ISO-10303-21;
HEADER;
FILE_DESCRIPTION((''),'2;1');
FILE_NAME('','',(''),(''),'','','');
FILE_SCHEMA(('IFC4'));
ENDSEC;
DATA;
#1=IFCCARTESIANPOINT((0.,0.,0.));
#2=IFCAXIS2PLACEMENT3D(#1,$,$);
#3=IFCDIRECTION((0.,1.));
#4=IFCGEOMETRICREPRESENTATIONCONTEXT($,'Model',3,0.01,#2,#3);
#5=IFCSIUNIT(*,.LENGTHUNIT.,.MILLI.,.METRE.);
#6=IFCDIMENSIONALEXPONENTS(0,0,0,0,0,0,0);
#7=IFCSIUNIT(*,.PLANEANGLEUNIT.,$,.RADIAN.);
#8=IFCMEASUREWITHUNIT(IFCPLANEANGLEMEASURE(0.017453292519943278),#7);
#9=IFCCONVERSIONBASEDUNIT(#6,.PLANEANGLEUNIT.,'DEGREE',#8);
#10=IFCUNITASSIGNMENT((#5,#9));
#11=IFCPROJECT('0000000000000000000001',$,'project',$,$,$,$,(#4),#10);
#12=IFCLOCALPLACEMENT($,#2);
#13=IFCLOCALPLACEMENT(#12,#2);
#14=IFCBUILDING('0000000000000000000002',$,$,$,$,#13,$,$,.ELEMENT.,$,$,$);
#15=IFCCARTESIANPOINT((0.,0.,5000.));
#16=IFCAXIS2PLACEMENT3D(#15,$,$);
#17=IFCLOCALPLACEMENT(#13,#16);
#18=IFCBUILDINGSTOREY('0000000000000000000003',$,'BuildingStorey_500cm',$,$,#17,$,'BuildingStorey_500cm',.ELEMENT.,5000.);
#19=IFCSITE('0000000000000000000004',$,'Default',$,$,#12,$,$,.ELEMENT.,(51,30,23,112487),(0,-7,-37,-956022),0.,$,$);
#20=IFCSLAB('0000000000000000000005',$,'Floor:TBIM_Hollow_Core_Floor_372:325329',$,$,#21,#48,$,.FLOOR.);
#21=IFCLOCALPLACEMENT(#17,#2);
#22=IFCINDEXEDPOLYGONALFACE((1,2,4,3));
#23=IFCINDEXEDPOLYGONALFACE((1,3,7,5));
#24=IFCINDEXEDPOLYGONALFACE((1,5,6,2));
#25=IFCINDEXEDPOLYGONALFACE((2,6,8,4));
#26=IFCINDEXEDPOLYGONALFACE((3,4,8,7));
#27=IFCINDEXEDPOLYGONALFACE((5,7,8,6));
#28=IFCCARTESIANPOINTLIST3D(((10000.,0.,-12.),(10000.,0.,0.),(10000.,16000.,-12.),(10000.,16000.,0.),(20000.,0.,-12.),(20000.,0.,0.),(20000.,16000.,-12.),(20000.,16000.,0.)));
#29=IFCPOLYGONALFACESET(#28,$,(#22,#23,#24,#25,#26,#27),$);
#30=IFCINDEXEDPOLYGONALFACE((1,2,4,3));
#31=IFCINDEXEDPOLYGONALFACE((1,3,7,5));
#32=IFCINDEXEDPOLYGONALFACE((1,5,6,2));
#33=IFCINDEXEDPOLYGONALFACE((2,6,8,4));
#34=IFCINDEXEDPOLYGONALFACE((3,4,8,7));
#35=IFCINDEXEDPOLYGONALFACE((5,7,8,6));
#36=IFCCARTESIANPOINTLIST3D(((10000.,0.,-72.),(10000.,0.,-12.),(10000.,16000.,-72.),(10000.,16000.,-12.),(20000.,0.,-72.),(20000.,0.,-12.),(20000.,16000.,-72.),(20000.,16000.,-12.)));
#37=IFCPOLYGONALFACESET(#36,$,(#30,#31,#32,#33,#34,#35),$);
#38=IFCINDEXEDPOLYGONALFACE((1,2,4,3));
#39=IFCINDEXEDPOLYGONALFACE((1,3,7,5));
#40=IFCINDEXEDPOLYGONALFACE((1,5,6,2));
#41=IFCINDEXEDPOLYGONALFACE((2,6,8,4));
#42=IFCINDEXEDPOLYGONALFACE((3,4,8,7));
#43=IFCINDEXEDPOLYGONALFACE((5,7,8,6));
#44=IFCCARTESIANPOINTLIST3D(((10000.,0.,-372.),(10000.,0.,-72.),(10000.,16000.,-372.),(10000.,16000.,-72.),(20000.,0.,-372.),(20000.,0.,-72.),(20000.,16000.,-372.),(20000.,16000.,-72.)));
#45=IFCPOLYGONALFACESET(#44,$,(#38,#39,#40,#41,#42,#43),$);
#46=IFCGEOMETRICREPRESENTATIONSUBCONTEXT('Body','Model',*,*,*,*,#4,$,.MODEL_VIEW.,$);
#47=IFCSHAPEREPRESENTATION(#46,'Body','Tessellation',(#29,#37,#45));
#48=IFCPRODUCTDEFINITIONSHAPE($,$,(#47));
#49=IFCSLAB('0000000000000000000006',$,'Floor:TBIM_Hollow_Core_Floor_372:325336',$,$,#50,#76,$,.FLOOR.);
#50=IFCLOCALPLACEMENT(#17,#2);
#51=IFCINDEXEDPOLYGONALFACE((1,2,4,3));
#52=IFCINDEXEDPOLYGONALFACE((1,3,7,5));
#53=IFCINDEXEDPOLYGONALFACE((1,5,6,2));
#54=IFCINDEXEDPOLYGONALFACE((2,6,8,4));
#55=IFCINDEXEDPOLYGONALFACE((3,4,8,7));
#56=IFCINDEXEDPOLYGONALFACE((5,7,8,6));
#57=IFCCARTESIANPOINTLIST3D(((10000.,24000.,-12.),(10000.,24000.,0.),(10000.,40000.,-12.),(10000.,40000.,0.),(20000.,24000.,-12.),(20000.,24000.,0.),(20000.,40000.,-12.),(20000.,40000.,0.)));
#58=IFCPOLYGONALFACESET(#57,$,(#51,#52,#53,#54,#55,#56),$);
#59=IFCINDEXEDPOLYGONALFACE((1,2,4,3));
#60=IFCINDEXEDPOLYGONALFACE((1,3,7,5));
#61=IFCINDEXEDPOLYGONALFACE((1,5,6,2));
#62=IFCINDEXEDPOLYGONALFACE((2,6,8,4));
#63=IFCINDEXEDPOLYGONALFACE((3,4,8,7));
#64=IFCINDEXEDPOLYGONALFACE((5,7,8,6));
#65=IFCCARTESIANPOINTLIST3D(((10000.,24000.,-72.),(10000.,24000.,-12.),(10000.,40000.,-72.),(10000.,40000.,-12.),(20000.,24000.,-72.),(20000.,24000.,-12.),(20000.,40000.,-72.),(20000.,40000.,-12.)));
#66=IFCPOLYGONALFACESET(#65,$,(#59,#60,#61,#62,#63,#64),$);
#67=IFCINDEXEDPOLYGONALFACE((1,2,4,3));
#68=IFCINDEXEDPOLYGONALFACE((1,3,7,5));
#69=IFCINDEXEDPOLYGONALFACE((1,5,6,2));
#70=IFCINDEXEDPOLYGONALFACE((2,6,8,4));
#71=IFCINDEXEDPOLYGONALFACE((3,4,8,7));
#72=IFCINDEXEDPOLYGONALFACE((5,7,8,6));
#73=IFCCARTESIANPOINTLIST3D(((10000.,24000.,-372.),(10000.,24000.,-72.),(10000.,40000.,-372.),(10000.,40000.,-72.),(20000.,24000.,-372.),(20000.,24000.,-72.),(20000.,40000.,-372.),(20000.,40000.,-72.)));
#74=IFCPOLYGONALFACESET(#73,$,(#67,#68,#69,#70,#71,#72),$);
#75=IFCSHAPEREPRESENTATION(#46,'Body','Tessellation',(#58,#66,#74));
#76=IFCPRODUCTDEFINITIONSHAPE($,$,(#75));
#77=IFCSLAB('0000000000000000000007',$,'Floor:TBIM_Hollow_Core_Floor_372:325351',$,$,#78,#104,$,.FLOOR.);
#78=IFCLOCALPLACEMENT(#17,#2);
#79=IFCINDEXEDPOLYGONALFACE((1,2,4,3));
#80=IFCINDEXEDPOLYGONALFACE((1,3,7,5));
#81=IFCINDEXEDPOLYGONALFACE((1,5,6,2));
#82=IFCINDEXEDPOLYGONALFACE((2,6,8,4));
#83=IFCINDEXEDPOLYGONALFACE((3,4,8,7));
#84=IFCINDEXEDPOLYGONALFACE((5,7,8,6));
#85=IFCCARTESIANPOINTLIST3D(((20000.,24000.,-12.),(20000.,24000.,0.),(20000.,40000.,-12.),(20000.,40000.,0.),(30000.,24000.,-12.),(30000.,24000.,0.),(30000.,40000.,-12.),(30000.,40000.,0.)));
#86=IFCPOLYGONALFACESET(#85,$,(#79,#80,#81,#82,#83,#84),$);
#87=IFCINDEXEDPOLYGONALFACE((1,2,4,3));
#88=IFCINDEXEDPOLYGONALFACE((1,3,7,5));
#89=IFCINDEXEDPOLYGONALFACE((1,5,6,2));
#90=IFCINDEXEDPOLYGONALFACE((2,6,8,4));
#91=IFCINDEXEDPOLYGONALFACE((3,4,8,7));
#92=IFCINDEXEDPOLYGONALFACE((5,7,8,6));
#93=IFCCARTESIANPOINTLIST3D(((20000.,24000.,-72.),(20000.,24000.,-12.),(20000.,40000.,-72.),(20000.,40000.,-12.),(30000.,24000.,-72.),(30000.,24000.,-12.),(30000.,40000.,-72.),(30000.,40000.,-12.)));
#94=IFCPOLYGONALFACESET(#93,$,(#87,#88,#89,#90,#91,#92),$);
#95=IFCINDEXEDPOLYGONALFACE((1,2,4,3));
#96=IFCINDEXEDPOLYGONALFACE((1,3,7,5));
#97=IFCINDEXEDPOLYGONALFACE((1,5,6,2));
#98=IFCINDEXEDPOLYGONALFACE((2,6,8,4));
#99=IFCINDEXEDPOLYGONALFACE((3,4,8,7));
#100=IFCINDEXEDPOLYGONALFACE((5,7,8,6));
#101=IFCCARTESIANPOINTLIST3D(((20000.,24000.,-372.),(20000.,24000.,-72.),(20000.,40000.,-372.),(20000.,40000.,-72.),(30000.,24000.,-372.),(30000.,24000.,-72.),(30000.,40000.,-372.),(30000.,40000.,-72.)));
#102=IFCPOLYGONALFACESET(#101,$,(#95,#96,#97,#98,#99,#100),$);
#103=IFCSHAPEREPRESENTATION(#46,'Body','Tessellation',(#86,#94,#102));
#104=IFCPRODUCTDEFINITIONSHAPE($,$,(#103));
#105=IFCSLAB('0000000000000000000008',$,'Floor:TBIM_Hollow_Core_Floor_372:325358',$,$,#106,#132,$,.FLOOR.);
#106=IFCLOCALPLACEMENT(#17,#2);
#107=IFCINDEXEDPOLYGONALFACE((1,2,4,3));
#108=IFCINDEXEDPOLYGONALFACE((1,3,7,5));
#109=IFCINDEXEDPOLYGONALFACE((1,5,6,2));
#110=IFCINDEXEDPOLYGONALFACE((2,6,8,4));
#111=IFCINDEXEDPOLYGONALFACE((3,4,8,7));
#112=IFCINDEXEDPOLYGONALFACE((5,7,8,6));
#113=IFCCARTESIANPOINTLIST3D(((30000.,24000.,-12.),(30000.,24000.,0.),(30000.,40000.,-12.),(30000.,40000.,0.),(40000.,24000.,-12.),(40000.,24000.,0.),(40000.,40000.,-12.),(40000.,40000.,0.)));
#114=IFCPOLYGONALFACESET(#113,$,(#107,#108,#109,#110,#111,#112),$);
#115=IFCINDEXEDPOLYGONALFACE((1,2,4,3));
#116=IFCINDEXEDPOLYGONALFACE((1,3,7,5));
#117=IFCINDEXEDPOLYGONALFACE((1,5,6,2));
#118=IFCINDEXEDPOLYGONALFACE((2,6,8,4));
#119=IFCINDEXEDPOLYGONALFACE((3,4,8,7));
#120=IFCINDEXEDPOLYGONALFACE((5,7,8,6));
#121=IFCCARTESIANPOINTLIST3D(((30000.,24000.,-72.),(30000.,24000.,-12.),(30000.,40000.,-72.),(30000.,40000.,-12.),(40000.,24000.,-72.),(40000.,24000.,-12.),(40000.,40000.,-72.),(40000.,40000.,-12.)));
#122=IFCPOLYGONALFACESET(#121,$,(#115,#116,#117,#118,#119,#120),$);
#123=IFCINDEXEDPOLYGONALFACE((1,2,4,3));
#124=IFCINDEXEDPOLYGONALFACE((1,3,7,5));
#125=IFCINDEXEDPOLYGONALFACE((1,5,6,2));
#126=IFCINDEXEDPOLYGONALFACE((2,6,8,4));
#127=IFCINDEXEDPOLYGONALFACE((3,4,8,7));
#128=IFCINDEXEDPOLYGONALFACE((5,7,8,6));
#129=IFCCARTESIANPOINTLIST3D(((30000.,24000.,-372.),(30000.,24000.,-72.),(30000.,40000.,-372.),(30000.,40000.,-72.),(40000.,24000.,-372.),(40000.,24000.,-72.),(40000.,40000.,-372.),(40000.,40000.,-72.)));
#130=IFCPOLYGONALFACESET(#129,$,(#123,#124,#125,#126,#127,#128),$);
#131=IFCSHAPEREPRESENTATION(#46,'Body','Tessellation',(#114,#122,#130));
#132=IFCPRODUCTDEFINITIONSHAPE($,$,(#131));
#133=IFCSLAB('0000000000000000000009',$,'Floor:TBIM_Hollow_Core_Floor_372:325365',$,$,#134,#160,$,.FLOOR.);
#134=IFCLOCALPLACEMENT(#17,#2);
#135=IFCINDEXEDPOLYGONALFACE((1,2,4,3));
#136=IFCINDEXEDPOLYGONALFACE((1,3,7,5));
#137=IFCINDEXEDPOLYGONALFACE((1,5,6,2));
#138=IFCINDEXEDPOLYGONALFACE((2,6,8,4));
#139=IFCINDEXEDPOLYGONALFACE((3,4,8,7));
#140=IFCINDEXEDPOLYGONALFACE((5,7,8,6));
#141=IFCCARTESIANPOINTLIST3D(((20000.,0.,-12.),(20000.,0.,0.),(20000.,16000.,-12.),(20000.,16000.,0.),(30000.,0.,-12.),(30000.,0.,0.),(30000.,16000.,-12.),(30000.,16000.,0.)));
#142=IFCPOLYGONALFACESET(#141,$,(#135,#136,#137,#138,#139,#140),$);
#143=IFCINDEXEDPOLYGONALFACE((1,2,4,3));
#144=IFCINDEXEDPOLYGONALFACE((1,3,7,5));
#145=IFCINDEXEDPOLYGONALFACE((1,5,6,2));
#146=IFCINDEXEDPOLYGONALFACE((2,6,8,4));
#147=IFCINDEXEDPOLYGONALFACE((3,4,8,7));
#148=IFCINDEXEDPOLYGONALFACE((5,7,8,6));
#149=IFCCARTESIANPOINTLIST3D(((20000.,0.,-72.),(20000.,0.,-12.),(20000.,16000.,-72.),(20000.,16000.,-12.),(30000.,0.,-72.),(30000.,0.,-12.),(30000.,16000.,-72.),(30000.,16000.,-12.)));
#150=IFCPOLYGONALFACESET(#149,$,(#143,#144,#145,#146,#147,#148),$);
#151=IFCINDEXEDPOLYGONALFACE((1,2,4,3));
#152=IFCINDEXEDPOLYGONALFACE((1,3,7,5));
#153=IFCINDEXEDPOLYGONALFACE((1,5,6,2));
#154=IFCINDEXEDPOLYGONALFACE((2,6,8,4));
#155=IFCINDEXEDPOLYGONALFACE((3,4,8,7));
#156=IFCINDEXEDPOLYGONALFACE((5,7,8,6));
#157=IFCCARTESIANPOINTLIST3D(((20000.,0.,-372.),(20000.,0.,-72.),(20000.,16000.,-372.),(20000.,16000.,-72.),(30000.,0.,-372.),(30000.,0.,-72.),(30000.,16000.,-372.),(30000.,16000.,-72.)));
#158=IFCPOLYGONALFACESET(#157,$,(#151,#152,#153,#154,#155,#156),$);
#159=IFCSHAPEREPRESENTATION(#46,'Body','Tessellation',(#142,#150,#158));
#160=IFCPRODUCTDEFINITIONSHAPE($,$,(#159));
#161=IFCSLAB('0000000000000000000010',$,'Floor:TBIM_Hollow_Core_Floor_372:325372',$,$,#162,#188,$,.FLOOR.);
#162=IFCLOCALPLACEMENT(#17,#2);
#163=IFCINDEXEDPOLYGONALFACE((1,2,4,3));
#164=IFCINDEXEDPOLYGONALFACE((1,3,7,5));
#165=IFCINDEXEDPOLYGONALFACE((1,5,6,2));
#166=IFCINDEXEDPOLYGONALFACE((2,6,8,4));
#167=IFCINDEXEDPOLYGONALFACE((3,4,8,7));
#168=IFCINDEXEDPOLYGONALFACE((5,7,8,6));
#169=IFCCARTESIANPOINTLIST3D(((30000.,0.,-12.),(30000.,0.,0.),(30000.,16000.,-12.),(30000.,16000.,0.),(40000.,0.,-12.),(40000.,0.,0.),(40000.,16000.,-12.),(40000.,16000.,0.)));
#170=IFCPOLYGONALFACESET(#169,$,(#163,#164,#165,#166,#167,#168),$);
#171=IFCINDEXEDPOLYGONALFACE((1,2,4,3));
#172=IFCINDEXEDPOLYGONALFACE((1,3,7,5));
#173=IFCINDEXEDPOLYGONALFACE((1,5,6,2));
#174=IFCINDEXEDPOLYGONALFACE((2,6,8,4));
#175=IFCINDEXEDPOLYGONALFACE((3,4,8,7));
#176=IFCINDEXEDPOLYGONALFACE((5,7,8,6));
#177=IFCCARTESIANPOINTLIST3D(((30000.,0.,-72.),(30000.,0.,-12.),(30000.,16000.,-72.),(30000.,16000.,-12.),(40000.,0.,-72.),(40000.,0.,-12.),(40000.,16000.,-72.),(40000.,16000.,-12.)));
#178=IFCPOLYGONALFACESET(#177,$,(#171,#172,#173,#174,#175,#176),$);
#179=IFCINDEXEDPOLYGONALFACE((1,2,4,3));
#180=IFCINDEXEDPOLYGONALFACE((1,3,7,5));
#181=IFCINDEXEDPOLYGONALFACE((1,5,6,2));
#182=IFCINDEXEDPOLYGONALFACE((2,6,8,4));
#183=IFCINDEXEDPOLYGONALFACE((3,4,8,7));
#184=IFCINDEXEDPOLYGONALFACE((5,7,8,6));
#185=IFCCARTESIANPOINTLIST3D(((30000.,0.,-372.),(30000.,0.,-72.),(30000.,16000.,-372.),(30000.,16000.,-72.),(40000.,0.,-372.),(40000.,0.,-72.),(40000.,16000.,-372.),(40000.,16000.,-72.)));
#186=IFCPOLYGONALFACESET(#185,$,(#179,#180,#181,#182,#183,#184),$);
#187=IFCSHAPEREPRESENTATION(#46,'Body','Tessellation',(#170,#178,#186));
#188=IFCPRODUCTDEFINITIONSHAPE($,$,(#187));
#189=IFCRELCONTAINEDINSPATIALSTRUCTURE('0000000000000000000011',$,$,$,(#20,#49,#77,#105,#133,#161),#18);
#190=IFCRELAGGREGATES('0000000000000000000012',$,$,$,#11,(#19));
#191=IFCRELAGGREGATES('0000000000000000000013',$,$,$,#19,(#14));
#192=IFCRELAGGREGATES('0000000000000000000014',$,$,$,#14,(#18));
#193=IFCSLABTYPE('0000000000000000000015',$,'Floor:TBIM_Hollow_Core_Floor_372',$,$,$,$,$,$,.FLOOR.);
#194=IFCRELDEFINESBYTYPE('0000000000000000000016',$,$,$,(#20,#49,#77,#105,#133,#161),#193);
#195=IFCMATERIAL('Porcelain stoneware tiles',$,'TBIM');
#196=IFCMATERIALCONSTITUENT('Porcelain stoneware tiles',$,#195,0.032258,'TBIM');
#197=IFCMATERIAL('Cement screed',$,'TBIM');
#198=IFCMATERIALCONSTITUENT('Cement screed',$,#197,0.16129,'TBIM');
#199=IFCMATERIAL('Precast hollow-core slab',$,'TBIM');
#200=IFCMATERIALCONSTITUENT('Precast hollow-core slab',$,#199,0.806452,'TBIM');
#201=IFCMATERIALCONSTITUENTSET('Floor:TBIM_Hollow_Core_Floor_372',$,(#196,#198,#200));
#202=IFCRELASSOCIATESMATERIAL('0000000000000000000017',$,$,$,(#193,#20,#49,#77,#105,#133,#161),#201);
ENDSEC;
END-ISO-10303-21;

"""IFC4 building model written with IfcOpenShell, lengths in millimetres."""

from ifc_helpers import new_model, entity, si_unit, converted_unit, direction, frame, origin, place, context, subcontext, project, spatial, indexed_curve, outline, extrude, material, constituent, constituent_set, type_object, element, save


model = new_model("IFC4")

# Units and contexts
model_context = context("Model", 3, precision=0.01, world=origin(), true_north=direction((0.0, 1.0)))
body_context = subcontext(model_context, "Body", "Model", "MODEL_VIEW")
ifc_project = project(units=[si_unit("LENGTHUNIT", "METRE", prefix="MILLI"), converted_unit("PLANEANGLEUNIT", "DEGREE", entity("IfcPlaneAngleMeasure", 0.017453292519943278), si_unit("PLANEANGLEUNIT", "RADIAN"), dimensions=[0, 0, 0, 0, 0, 0, 0])], contexts=[model_context])

# Site, building, storey
site_placement = place(None, origin())
site = spatial("IfcSite", under=ifc_project, at=site_placement, Name="Default", CompositionType="ELEMENT", RefLatitude=(51, 30, 23, 112487), RefLongitude=(0, -7, -37, -956022), RefElevation=0.0)
building_placement = place(site_placement, origin())
building = spatial("IfcBuilding", under=site, at=building_placement, CompositionType="ELEMENT")
storey_placement = place(building_placement, frame((0.0, 0.0, 5000.0)))
storey = spatial("IfcBuildingStorey", under=building, at=storey_placement, Name="BuildingStorey_500cm", LongName="BuildingStorey_500cm", CompositionType="ELEMENT", Elevation=5000.0)

# Slabs
ifc_material_1 = material(Name="Porcelain stoneware tiles", Category="TBIM")
ifc_constituent_1 = constituent(ifc_material_1, Name="Porcelain stoneware tiles", Category="TBIM", fraction=0.032258)
ifc_material_2 = material(Name="Cement screed", Category="TBIM")
ifc_constituent_2 = constituent(ifc_material_2, Name="Cement screed", Category="TBIM", fraction=0.16129)
ifc_material_3 = material(Name="Precast hollow-core slab", Category="TBIM")
ifc_constituent_3 = constituent(ifc_material_3, Name="Precast hollow-core slab", Category="TBIM", fraction=0.806452)
ifc_constituent_set_1 = constituent_set(constituents=[ifc_constituent_1, ifc_constituent_2, ifc_constituent_3], Name="Floor:TBIM_Hollow_Core_Floor_372")
slab_type = type_object("IfcSlabType", Name="Floor:TBIM_Hollow_Core_Floor_372", PredefinedType="FLOOR", material=ifc_constituent_set_1)
slab_1_placement = place(storey_placement, origin())
element("IfcSlab", 1, at=slab_1_placement, inside=storey, type_object=slab_type, material=ifc_constituent_set_1, Name="Floor:TBIM_Hollow_Core_Floor_372:325329", PredefinedType="FLOOR", context=body_context, shape_type="SweptSolid", body=[
    extrude(outline(indexed_curve([(-5000.0, -8000.0), (5000.0, -8000.0), (5000.0, 8000.0), (-5000.0, 8000.0), (-5000.0, -8000.0)], self_intersect=False)), frame((15000.0, 8000.0, -12.0), z_axis=(0.0, 0.0, 1.0), x_axis=(-1.0, 0.0, 0.0)), (0.0, 0.0, 1.0), 12.0),
    extrude(outline(indexed_curve([(-5000.0, -8000.0), (5000.0, -8000.0), (5000.0, 8000.0), (-5000.0, 8000.0), (-5000.0, -8000.0)], self_intersect=False)), frame((15000.0, 8000.0, -72.0), z_axis=(0.0, 0.0, 1.0), x_axis=(-1.0, 0.0, 0.0)), (0.0, 0.0, 1.0), 60.0),
    extrude(outline(indexed_curve([(-5000.0, -8000.0), (5000.0, -8000.0), (5000.0, 8000.0), (-5000.0, 8000.0), (-5000.0, -8000.0)], self_intersect=False)), frame((15000.0, 8000.0, -372.0), z_axis=(0.0, 0.0, 1.0), x_axis=(-1.0, 0.0, 0.0)), (0.0, 0.0, 1.0), 300.0),
])
slab_2_placement = place(storey_placement, origin())
element("IfcSlab", 2, at=slab_2_placement, inside=storey, type_object=slab_type, material=ifc_constituent_set_1, Name="Floor:TBIM_Hollow_Core_Floor_372:325336", PredefinedType="FLOOR", context=body_context, shape_type="SweptSolid", body=[
    extrude(outline(indexed_curve([(-5000.0, -8000.0), (5000.0, -8000.0), (5000.0, 8000.0), (-5000.0, 8000.0), (-5000.0, -8000.0)], self_intersect=False)), frame((15000.0, 32000.0, -12.0), z_axis=(0.0, 0.0, 1.0), x_axis=(-1.0, 0.0, 0.0)), (0.0, 0.0, 1.0), 12.0),
    extrude(outline(indexed_curve([(-5000.0, -8000.0), (5000.0, -8000.0), (5000.0, 8000.0), (-5000.0, 8000.0), (-5000.0, -8000.0)], self_intersect=False)), frame((15000.0, 32000.0, -72.0), z_axis=(0.0, 0.0, 1.0), x_axis=(-1.0, 0.0, 0.0)), (0.0, 0.0, 1.0), 60.0),
    extrude(outline(indexed_curve([(-5000.0, -8000.0), (5000.0, -8000.0), (5000.0, 8000.0), (-5000.0, 8000.0), (-5000.0, -8000.0)], self_intersect=False)), frame((15000.0, 32000.0, -372.0), z_axis=(0.0, 0.0, 1.0), x_axis=(-1.0, 0.0, 0.0)), (0.0, 0.0, 1.0), 300.0),
])
slab_3_placement = place(storey_placement, origin())
element("IfcSlab", 3, at=slab_3_placement, inside=storey, type_object=slab_type, material=ifc_constituent_set_1, Name="Floor:TBIM_Hollow_Core_Floor_372:325351", PredefinedType="FLOOR", context=body_context, shape_type="SweptSolid", body=[
    extrude(outline(indexed_curve([(-5000.0, -8000.0), (5000.0, -8000.0), (5000.0, 8000.0), (-5000.0, 8000.0), (-5000.0, -8000.0)], self_intersect=False)), frame((25000.0, 32000.0, -12.0), z_axis=(0.0, 0.0, 1.0), x_axis=(-1.0, 0.0, 0.0)), (0.0, 0.0, 1.0), 12.0),
    extrude(outline(indexed_curve([(-5000.0, -8000.0), (5000.0, -8000.0), (5000.0, 8000.0), (-5000.0, 8000.0), (-5000.0, -8000.0)], self_intersect=False)), frame((25000.0, 32000.0, -72.0), z_axis=(0.0, 0.0, 1.0), x_axis=(-1.0, 0.0, 0.0)), (0.0, 0.0, 1.0), 60.0),
    extrude(outline(indexed_curve([(-5000.0, -8000.0), (5000.0, -8000.0), (5000.0, 8000.0), (-5000.0, 8000.0), (-5000.0, -8000.0)], self_intersect=False)), frame((25000.0, 32000.0, -372.0), z_axis=(0.0, 0.0, 1.0), x_axis=(-1.0, 0.0, 0.0)), (0.0, 0.0, 1.0), 300.0),
])
slab_4_placement = place(storey_placement, origin())
element("IfcSlab", 4, at=slab_4_placement, inside=storey, type_object=slab_type, material=ifc_constituent_set_1, Name="Floor:TBIM_Hollow_Core_Floor_372:325358", PredefinedType="FLOOR", context=body_context, shape_type="SweptSolid", body=[
    extrude(outline(indexed_curve([(-5000.0, -8000.0), (5000.0, -8000.0), (5000.0, 8000.0), (-5000.0, 8000.0), (-5000.0, -8000.0)], self_intersect=False)), frame((35000.0, 32000.0, -12.0), z_axis=(0.0, 0.0, 1.0), x_axis=(-1.0, 0.0, 0.0)), (0.0, 0.0, 1.0), 12.0),
    extrude(outline(indexed_curve([(-5000.0, -8000.0), (5000.0, -8000.0), (5000.0, 8000.0), (-5000.0, 8000.0), (-5000.0, -8000.0)], self_intersect=False)), frame((35000.0, 32000.0, -72.0), z_axis=(0.0, 0.0, 1.0), x_axis=(-1.0, 0.0, 0.0)), (0.0, 0.0, 1.0), 60.0),
    extrude(outline(indexed_curve([(-5000.0, -8000.0), (5000.0, -8000.0), (5000.0, 8000.0), (-5000.0, 8000.0), (-5000.0, -8000.0)], self_intersect=False)), frame((35000.0, 32000.0, -372.0), z_axis=(0.0, 0.0, 1.0), x_axis=(-1.0, 0.0, 0.0)), (0.0, 0.0, 1.0), 300.0),
])
slab_5_placement = place(storey_placement, origin())
element("IfcSlab", 5, at=slab_5_placement, inside=storey, type_object=slab_type, material=ifc_constituent_set_1, Name="Floor:TBIM_Hollow_Core_Floor_372:325365", PredefinedType="FLOOR", context=body_context, shape_type="SweptSolid", body=[
    extrude(outline(indexed_curve([(-5000.0, -8000.0), (5000.0, -8000.0), (5000.0, 8000.0), (-5000.0, 8000.0), (-5000.0, -8000.0)], self_intersect=False)), frame((25000.0, 8000.0, -12.0), z_axis=(0.0, 0.0, 1.0), x_axis=(-1.0, 0.0, 0.0)), (0.0, 0.0, 1.0), 12.0),
    extrude(outline(indexed_curve([(-5000.0, -8000.0), (5000.0, -8000.0), (5000.0, 8000.0), (-5000.0, 8000.0), (-5000.0, -8000.0)], self_intersect=False)), frame((25000.0, 8000.0, -72.0), z_axis=(0.0, 0.0, 1.0), x_axis=(-1.0, 0.0, 0.0)), (0.0, 0.0, 1.0), 60.0),
    extrude(outline(indexed_curve([(-5000.0, -8000.0), (5000.0, -8000.0), (5000.0, 8000.0), (-5000.0, 8000.0), (-5000.0, -8000.0)], self_intersect=False)), frame((25000.0, 8000.0, -372.0), z_axis=(0.0, 0.0, 1.0), x_axis=(-1.0, 0.0, 0.0)), (0.0, 0.0, 1.0), 300.0),
])
slab_6_placement = place(storey_placement, origin())
element("IfcSlab", 6, at=slab_6_placement, inside=storey, type_object=slab_type, material=ifc_constituent_set_1, Name="Floor:TBIM_Hollow_Core_Floor_372:325372", PredefinedType="FLOOR", context=body_context, shape_type="SweptSolid", body=[
    extrude(outline(indexed_curve([(-5000.0, -8000.0), (5000.0, -8000.0), (5000.0, 8000.0), (-5000.0, 8000.0), (-5000.0, -8000.0)], self_intersect=False)), frame((35000.0, 8000.0, -12.0), z_axis=(0.0, 0.0, 1.0), x_axis=(-1.0, 0.0, 0.0)), (0.0, 0.0, 1.0), 12.0),
    extrude(outline(indexed_curve([(-5000.0, -8000.0), (5000.0, -8000.0), (5000.0, 8000.0), (-5000.0, 8000.0), (-5000.0, -8000.0)], self_intersect=False)), frame((35000.0, 8000.0, -72.0), z_axis=(0.0, 0.0, 1.0), x_axis=(-1.0, 0.0, 0.0)), (0.0, 0.0, 1.0), 60.0),
    extrude(outline(indexed_curve([(-5000.0, -8000.0), (5000.0, -8000.0), (5000.0, 8000.0), (-5000.0, 8000.0), (-5000.0, -8000.0)], self_intersect=False)), frame((35000.0, 8000.0, -372.0), z_axis=(0.0, 0.0, 1.0), x_axis=(-1.0, 0.0, 0.0)), (0.0, 0.0, 1.0), 300.0),
])

save(model, "model.ifc")
